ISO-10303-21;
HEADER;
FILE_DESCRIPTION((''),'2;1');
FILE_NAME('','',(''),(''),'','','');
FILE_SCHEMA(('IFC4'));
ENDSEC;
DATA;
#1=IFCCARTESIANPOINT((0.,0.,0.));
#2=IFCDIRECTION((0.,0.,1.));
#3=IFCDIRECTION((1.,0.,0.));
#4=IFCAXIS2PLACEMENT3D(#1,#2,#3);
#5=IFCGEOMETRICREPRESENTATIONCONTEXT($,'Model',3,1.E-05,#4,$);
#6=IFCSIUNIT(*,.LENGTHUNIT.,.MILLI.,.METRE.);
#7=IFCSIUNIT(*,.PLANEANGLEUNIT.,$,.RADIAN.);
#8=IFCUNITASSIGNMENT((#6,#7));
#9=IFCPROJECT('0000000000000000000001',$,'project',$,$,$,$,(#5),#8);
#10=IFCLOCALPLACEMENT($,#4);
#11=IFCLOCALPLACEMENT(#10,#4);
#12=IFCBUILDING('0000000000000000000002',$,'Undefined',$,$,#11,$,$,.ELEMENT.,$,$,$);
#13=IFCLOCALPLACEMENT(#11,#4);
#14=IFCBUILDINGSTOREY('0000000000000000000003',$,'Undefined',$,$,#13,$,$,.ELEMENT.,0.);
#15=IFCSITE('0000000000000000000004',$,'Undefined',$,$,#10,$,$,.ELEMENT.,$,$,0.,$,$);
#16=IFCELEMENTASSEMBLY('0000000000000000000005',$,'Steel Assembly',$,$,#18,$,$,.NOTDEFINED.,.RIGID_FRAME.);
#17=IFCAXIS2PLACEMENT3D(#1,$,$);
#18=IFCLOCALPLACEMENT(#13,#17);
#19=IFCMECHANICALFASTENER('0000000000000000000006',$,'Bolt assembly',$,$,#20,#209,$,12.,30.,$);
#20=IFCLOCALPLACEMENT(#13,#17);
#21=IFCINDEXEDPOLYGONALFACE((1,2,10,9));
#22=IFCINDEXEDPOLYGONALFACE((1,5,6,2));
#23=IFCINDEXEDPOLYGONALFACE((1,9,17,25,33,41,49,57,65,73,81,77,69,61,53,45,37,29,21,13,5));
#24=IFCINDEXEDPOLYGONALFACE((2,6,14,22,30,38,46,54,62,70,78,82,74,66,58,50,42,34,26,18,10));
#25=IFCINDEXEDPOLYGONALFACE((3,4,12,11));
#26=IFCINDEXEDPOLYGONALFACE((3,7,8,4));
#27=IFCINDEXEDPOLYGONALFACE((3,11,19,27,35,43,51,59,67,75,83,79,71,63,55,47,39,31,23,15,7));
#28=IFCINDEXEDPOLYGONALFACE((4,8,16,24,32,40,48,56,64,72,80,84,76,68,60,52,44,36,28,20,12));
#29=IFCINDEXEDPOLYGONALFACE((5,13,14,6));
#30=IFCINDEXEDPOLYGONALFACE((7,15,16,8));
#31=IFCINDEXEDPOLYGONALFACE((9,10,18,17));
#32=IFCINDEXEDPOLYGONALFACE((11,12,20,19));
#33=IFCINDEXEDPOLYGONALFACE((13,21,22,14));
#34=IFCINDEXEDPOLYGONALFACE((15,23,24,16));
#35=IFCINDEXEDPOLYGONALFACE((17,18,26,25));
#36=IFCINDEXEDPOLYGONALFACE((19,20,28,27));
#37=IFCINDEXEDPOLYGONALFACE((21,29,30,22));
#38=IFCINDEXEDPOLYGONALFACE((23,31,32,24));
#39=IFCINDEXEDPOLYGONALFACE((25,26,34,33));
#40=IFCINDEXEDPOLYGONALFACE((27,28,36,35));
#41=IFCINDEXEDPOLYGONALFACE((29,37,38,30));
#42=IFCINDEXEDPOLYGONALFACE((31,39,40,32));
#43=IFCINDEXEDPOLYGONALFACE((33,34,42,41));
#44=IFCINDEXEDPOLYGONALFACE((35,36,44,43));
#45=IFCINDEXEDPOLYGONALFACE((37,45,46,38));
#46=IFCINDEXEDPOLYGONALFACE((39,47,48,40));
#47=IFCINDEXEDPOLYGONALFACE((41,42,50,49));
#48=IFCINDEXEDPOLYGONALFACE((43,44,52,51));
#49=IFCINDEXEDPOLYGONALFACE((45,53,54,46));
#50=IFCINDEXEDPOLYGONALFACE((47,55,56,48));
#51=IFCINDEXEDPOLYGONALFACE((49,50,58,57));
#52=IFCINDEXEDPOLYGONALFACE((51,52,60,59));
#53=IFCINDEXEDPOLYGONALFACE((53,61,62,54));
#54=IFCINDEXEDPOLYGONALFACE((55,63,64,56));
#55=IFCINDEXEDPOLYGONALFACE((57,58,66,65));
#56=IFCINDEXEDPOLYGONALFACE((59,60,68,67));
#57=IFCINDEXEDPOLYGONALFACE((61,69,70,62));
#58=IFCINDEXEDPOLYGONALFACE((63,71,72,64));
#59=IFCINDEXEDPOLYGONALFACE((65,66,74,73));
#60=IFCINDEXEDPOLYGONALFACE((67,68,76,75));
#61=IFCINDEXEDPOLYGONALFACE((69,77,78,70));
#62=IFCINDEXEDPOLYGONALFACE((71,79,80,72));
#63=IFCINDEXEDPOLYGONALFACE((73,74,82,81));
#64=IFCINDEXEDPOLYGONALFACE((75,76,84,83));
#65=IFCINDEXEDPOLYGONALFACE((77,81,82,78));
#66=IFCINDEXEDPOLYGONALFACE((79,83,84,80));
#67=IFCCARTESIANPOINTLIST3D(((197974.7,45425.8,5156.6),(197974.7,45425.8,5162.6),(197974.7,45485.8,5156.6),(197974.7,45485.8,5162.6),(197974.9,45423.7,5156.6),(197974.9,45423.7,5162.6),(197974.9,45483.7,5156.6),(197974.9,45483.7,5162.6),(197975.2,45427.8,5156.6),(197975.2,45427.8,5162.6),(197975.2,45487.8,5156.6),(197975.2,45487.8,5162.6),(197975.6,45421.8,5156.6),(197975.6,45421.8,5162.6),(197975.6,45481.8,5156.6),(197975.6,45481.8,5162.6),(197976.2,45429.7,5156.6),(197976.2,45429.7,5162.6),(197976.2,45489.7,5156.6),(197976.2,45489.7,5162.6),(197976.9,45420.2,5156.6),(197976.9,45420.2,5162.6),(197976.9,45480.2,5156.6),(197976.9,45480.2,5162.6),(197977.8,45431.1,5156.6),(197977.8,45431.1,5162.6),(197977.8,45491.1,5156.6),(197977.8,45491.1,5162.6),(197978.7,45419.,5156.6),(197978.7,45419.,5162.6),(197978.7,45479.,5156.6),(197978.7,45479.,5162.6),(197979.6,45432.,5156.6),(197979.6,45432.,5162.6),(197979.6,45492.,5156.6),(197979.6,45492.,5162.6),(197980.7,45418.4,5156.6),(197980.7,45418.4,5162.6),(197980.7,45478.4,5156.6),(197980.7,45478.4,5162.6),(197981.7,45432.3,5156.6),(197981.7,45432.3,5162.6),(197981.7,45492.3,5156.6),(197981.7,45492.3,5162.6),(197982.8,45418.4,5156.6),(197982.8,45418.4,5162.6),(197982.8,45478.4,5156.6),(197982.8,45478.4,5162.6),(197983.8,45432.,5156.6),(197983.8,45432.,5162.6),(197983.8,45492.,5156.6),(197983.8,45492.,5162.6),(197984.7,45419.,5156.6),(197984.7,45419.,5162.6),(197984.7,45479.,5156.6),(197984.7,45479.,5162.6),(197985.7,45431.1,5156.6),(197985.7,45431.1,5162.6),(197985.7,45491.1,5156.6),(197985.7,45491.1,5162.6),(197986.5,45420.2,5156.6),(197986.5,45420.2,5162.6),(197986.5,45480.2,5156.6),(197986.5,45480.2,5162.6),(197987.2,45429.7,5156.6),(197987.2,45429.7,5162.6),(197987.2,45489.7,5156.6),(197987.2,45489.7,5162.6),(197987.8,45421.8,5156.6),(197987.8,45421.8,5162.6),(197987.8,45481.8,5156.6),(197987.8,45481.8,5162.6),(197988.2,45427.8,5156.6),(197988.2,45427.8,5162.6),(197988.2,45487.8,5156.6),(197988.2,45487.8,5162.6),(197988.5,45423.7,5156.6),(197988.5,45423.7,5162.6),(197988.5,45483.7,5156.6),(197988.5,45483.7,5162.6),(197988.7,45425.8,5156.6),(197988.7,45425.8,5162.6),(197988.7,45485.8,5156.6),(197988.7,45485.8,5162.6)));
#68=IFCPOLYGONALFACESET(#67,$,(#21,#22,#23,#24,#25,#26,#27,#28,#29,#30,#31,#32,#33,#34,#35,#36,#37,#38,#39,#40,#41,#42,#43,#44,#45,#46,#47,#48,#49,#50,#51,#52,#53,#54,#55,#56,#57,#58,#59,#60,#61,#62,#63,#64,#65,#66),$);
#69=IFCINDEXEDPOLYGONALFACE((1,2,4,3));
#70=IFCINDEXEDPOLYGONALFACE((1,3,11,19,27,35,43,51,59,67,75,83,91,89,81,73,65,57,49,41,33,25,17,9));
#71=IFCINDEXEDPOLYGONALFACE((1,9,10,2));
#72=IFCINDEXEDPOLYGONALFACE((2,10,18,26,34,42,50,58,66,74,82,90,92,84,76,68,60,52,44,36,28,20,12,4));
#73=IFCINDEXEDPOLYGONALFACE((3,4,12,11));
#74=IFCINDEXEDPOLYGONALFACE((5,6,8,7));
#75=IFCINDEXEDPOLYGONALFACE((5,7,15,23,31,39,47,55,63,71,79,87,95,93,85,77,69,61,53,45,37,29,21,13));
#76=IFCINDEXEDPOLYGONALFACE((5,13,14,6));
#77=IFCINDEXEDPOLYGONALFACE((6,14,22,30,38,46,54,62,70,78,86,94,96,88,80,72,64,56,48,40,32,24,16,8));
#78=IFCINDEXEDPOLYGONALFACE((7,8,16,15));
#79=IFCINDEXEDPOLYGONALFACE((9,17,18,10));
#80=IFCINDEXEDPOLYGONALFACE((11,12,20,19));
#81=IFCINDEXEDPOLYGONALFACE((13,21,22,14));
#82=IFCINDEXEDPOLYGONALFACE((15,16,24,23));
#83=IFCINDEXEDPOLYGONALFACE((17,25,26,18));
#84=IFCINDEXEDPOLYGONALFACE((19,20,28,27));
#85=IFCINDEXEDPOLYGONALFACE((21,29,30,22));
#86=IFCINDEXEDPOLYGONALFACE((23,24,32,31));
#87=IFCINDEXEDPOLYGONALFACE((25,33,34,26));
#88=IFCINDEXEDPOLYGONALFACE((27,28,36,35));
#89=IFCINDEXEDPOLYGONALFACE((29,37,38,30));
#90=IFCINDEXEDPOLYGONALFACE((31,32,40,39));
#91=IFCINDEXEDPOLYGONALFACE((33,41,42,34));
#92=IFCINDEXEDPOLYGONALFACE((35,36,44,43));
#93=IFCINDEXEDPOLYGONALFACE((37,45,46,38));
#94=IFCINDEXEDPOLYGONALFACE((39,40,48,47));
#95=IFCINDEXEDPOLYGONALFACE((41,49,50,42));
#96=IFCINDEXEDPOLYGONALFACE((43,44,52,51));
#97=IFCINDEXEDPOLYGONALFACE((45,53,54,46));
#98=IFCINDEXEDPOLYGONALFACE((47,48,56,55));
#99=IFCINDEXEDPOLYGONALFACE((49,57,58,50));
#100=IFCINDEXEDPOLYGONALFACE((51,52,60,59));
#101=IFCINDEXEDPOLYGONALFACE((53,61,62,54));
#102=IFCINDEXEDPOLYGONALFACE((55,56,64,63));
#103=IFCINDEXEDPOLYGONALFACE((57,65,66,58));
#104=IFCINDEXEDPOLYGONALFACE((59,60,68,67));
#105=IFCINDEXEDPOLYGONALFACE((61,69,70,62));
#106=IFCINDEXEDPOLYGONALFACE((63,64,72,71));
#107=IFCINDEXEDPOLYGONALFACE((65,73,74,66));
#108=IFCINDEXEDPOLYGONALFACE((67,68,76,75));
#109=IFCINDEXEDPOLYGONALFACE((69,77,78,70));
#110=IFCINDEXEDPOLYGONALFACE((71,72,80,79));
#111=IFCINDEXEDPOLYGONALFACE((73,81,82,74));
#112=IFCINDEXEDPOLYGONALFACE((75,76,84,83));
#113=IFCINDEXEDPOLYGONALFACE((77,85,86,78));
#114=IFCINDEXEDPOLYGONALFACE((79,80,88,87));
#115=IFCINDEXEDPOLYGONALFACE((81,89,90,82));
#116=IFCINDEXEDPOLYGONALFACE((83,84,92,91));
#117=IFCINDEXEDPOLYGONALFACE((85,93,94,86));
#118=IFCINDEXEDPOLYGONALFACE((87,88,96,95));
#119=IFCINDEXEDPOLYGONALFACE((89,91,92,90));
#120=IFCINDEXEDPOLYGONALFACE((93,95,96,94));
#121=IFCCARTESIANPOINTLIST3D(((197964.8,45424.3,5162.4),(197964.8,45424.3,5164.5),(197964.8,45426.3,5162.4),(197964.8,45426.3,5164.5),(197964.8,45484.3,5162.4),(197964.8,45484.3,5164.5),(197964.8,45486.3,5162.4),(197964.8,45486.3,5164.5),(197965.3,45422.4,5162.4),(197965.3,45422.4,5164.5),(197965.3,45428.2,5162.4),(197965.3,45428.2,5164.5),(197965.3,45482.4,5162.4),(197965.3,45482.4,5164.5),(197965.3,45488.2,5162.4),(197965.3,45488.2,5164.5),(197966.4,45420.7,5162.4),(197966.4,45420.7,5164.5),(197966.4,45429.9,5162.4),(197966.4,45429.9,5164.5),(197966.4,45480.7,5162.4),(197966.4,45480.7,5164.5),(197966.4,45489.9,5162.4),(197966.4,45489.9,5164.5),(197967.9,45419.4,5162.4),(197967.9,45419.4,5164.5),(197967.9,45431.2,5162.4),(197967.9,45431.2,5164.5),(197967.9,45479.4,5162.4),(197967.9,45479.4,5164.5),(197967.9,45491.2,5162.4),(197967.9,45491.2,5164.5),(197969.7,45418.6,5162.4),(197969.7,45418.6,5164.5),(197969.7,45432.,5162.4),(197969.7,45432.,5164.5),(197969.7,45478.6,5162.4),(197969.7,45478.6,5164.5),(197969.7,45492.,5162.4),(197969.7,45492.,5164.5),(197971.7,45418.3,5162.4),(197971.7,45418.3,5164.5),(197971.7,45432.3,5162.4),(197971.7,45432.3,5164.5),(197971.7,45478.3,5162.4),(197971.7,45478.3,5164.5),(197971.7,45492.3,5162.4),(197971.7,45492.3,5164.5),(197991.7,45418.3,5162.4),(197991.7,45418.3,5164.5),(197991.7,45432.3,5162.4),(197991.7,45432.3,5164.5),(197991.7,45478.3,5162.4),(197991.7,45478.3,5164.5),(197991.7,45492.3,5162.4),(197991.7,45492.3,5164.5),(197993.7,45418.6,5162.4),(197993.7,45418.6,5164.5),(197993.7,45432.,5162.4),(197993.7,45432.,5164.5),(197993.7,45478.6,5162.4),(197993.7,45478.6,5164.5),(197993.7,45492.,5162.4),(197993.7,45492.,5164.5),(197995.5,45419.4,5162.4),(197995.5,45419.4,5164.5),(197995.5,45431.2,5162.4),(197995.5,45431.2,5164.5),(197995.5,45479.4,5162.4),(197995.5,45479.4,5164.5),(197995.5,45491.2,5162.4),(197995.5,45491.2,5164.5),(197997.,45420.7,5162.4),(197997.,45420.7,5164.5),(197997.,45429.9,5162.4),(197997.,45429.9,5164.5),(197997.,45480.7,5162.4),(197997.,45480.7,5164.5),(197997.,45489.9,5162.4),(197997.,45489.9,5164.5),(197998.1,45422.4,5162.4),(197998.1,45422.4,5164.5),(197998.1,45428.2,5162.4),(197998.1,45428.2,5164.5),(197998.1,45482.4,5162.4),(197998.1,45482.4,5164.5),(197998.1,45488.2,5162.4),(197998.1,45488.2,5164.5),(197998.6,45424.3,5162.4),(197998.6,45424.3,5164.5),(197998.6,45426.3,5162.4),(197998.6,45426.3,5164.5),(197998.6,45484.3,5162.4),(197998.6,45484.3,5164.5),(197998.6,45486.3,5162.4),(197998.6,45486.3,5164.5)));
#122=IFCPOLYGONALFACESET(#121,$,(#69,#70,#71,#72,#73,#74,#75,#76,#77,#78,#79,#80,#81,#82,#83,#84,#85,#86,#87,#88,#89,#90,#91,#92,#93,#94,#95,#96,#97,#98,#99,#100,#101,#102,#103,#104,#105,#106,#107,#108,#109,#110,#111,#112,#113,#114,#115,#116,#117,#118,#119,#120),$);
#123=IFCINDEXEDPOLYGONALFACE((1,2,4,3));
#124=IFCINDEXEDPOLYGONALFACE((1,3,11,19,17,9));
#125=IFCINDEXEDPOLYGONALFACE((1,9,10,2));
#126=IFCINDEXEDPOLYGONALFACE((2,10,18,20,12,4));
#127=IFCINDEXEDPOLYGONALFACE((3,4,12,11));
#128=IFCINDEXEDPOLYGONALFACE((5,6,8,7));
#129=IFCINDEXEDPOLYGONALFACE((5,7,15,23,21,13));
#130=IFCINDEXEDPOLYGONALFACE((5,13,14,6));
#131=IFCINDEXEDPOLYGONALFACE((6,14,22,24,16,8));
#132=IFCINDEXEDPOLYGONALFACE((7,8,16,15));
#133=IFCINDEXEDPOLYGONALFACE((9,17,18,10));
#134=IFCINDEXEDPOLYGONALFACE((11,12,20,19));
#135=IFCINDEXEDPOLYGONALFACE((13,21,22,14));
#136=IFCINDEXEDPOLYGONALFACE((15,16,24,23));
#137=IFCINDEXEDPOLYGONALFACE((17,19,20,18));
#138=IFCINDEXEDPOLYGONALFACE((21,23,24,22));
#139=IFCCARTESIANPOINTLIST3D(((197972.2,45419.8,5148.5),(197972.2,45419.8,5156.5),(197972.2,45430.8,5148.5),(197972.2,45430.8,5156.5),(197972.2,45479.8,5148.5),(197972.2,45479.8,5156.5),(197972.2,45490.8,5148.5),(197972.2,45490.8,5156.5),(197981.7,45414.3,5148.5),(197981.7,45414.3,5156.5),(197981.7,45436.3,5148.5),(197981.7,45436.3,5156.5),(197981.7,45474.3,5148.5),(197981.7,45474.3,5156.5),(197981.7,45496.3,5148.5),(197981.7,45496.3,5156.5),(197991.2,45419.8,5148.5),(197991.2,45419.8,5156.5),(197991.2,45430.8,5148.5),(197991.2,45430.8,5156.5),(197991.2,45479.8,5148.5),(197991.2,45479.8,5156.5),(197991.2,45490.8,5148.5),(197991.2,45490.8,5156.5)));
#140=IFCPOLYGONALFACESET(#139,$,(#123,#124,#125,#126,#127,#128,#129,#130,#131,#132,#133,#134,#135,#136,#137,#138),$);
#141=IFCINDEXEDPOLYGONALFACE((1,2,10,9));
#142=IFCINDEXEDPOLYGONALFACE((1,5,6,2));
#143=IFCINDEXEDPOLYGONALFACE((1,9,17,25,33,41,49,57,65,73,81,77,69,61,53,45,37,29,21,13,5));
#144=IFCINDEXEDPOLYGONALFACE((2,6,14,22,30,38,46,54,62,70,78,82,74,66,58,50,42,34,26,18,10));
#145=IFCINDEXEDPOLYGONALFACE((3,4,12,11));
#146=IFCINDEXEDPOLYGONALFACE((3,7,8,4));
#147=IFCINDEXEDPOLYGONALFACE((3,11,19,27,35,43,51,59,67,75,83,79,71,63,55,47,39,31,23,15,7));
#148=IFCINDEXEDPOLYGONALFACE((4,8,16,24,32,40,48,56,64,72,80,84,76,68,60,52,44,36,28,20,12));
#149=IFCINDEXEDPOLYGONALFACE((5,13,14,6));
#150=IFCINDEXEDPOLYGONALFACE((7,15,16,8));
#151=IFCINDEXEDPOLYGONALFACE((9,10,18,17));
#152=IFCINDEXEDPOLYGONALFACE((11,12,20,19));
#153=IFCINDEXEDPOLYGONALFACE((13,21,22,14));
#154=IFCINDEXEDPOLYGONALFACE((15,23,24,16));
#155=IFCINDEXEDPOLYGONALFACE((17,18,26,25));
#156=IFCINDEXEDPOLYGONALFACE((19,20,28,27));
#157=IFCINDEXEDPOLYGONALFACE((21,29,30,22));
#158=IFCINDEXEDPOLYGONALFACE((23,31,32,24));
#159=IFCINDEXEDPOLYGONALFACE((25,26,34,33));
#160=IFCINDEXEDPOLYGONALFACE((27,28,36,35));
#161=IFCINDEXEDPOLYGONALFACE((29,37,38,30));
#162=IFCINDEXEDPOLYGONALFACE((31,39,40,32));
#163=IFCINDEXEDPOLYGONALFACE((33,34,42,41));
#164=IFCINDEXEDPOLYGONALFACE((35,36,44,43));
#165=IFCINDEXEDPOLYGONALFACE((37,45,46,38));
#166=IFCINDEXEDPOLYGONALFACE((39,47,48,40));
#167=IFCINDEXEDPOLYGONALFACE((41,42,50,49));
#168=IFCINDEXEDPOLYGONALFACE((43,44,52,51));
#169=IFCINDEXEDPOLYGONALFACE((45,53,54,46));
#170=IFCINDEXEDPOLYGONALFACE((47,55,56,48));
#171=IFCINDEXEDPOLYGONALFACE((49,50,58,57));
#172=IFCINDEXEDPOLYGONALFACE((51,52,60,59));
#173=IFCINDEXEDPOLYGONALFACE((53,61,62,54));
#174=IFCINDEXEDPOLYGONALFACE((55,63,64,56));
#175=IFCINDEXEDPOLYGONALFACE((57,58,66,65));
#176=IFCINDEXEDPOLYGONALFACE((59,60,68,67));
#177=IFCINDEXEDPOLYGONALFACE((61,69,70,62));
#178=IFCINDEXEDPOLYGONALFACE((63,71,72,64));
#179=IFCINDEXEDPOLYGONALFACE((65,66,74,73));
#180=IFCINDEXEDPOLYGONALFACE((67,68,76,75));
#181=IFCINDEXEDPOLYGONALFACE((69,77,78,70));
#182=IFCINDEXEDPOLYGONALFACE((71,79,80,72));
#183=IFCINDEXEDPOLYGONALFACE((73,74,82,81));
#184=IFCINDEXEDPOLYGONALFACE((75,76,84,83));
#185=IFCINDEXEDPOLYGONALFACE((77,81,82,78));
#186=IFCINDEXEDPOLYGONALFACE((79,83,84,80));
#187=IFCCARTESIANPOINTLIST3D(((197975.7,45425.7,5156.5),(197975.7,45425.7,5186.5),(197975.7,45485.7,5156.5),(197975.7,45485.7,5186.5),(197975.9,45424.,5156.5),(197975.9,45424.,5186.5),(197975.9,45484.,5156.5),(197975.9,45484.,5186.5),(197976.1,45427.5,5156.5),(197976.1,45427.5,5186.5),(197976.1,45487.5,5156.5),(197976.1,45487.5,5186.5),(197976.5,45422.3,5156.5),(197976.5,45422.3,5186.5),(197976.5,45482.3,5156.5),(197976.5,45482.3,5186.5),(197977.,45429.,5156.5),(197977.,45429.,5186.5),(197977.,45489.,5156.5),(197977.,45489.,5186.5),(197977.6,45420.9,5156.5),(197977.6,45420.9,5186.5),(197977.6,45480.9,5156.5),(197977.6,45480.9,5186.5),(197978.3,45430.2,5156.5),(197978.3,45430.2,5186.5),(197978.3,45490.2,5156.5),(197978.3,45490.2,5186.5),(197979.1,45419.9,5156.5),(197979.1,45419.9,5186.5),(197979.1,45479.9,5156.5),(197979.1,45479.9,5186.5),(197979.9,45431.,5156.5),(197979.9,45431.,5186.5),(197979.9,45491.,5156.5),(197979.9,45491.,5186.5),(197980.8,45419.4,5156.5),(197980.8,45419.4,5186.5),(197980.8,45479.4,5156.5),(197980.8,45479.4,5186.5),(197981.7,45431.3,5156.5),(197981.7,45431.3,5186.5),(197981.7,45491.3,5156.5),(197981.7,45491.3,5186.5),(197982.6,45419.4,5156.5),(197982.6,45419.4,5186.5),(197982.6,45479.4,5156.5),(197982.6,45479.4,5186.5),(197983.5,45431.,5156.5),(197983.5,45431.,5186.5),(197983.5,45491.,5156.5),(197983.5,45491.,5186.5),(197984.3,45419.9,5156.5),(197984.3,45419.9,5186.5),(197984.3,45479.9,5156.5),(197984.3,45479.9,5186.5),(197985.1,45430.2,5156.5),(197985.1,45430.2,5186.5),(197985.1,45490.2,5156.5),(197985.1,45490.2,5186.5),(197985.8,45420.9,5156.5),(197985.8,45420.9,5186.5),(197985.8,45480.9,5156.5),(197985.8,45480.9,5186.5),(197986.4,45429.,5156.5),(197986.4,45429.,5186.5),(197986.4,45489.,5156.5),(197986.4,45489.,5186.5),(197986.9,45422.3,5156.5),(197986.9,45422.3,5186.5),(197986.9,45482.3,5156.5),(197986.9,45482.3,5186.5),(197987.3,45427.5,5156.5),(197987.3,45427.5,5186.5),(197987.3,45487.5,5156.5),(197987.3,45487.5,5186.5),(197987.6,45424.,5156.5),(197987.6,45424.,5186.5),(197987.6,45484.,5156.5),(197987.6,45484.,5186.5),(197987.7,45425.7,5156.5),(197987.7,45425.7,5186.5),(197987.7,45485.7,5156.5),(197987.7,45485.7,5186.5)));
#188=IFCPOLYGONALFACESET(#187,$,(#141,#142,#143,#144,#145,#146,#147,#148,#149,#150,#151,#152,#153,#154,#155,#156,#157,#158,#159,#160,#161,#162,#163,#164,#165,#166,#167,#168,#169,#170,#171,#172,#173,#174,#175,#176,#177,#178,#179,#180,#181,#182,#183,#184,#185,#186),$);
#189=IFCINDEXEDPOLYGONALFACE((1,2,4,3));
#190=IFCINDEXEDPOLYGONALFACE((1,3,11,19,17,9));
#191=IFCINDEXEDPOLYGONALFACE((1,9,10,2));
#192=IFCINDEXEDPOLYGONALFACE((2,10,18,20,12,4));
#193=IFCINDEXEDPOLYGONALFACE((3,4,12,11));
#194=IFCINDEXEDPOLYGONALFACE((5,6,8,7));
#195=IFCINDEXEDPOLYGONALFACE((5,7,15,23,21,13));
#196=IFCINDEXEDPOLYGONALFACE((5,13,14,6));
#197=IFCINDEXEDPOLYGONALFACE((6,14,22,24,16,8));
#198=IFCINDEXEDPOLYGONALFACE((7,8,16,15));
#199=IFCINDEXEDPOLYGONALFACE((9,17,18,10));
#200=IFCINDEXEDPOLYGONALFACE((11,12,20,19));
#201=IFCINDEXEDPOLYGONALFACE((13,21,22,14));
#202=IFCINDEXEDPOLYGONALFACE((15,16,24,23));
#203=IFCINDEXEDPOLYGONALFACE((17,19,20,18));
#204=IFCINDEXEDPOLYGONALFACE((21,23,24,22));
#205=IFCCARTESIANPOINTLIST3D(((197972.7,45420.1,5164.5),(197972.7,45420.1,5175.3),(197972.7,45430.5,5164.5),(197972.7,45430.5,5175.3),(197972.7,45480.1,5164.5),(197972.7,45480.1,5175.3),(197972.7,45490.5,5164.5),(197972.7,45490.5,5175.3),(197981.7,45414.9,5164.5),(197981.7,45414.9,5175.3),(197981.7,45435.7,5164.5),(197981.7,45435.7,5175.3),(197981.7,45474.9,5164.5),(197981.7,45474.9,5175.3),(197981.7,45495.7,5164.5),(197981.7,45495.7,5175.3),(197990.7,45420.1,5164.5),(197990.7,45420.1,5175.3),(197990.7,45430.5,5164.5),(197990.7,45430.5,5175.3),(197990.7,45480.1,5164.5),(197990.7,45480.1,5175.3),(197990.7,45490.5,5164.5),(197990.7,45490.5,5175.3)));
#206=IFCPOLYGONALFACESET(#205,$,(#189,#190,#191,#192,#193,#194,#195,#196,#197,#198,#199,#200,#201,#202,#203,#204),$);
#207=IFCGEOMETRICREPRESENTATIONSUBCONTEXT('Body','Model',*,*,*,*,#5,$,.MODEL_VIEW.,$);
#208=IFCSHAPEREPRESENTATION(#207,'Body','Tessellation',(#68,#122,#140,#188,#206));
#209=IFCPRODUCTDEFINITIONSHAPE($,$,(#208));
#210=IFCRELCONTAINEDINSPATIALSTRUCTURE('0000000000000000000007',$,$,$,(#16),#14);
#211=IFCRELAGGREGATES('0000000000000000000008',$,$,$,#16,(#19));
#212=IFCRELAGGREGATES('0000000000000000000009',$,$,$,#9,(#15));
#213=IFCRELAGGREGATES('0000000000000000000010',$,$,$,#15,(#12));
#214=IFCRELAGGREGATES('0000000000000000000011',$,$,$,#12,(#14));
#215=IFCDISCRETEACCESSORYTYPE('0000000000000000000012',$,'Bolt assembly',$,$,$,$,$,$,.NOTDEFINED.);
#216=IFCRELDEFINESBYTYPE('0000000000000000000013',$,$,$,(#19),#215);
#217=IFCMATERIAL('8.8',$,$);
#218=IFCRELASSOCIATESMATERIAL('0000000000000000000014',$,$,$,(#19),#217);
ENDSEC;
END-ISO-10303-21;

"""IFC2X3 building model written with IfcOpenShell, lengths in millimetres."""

from ifc_helpers import new_model, si_unit, frame, frame_2d, origin_with_axes, origin_2d_with_axis, place, context, subcontext, project, spatial, polyline, circle_curve, parameter, trimmed, segment, composite_curve, circle, outline, extrude, source, transform, mapped, material, type_object, element, aggregate, save


model = new_model("IFC2X3")

# Units and contexts
model_context = context("Model", 3, precision=1e-05, world=origin_with_axes())
body_context = subcontext(model_context, "Body", "Model", "MODEL_VIEW")
ifc_project = project(units=[si_unit("LENGTHUNIT", "METRE", prefix="MILLI"), si_unit("PLANEANGLEUNIT", "RADIAN")], contexts=[model_context])

# Site, building, storey
site_placement = place(None, origin_with_axes())
site = spatial("IfcSite", under=ifc_project, at=site_placement, Name="Undefined", CompositionType="ELEMENT", RefElevation=0.0)
building_placement = place(site_placement, origin_with_axes())
building = spatial("IfcBuilding", under=site, at=building_placement, Name="Undefined", CompositionType="ELEMENT")
storey_placement = place(building_placement, origin_with_axes())
storey = spatial("IfcBuildingStorey", under=building, at=storey_placement, Name="Undefined", CompositionType="ELEMENT", Elevation=0.0)

# Element assembly
assembly_1_placement = place(storey_placement, origin_with_axes())
assembly_1 = element("IfcElementAssembly", 1, at=assembly_1_placement, inside=storey, Name="Steel Assembly", AssemblyPlace="NOTDEFINED", PredefinedType="RIGID_FRAME")

# Shared definitions
discrete_accessory_type_1 = type_object("IfcDiscreteAccessoryType", Name="Bolt assembly")
ifc_material_1 = material(Name="8.8")

# Mechanical fastener
shared_shape_1 = source(origin_with_axes(), body_context, "Body", "SweptSolid", [
    extrude(circle(Radius=7.0, at=origin_2d_with_axis()), frame((0.0, -2.9, 0.0), z_axis=(0.0, 1.0, 0.0), x_axis=(1.0, 0.0, 0.0)), (0.0, 0.0, 1.0), 6.0),
    extrude(outline(composite_curve([segment(polyline([(7.0, 10.0), (7.0, -10.0)]), True, "CONTINUOUS"), segment(trimmed(circle_curve(frame_2d((0.0, -10.0), x_axis=(1.0, 0.0)), 7.0), [parameter(0.0)], [parameter(3.1416)], False, "PARAMETER"), True, "CONTINUOUS"), segment(polyline([(-7.0, -10.0), (-7.0, 10.0)]), True, "CONTINUOUS"), segment(trimmed(circle_curve(frame_2d((0.0, 10.0), x_axis=(-1.0, 0.0)), 7.0), [parameter(0.0)], [parameter(3.1416)], False, "PARAMETER"), True, "DISCONTINUOUS")], self_intersect=False)), frame((0.0, 2.9, 0.0), z_axis=(0.0, 1.0, 0.0), x_axis=(1.0, 0.0, 0.0)), (0.0, 0.0, 1.0), 2.1),
    extrude(outline(polyline([(11.0, 0.0), (5.5, 9.5), (-5.5, 9.5), (-11.0, 0.0), (-5.5, -9.5), (5.5, -9.5), (11.0, 0.0)])), frame((0.0, -11.0, 0.0), z_axis=(0.0, 1.0, 0.0), x_axis=(1.0, 0.0, 0.0)), (0.0, 0.0, 1.0), 8.0),
    extrude(circle(Radius=6.0, at=origin_2d_with_axis()), frame((0.0, -3.0, 0.0), z_axis=(0.0, 1.0, 0.0), x_axis=(1.0, 0.0, 0.0)), (0.0, 0.0, 1.0), 30.0),
    extrude(outline(polyline([(10.4, 0.0), (5.2, 9.0), (-5.2, 9.0), (-10.4, 0.0), (-5.2, -9.0), (5.2, -9.0), (10.4, 0.0)])), frame((0.0, 5.0, 0.0), z_axis=(0.0, 1.0, 0.0), x_axis=(1.0, 0.0, 0.0)), (0.0, 0.0, 1.0), 10.8),
])
mechanical_fastener_1_placement = place(assembly_1_placement, frame((197936.7, 45380.3, 5159.5), z_axis=(1.0, 0.0, 0.0), x_axis=(0.0, 1.0, 0.0)))
mechanical_fastener_1 = element("IfcMechanicalFastener", 2, at=mechanical_fastener_1_placement, type_object=discrete_accessory_type_1, material=ifc_material_1, Name="Bolt assembly", NominalDiameter=12.0, NominalLength=30.0, context=body_context, shape_type="MappedRepresentation", body=[
    mapped(shared_shape_1, transform((45.0, 0.0, 45.0))),
    mapped(shared_shape_1, transform((105.0, 0.0, 45.0))),
])
aggregate(assembly_1, [mechanical_fastener_1])

save(model, "model.ifc")
